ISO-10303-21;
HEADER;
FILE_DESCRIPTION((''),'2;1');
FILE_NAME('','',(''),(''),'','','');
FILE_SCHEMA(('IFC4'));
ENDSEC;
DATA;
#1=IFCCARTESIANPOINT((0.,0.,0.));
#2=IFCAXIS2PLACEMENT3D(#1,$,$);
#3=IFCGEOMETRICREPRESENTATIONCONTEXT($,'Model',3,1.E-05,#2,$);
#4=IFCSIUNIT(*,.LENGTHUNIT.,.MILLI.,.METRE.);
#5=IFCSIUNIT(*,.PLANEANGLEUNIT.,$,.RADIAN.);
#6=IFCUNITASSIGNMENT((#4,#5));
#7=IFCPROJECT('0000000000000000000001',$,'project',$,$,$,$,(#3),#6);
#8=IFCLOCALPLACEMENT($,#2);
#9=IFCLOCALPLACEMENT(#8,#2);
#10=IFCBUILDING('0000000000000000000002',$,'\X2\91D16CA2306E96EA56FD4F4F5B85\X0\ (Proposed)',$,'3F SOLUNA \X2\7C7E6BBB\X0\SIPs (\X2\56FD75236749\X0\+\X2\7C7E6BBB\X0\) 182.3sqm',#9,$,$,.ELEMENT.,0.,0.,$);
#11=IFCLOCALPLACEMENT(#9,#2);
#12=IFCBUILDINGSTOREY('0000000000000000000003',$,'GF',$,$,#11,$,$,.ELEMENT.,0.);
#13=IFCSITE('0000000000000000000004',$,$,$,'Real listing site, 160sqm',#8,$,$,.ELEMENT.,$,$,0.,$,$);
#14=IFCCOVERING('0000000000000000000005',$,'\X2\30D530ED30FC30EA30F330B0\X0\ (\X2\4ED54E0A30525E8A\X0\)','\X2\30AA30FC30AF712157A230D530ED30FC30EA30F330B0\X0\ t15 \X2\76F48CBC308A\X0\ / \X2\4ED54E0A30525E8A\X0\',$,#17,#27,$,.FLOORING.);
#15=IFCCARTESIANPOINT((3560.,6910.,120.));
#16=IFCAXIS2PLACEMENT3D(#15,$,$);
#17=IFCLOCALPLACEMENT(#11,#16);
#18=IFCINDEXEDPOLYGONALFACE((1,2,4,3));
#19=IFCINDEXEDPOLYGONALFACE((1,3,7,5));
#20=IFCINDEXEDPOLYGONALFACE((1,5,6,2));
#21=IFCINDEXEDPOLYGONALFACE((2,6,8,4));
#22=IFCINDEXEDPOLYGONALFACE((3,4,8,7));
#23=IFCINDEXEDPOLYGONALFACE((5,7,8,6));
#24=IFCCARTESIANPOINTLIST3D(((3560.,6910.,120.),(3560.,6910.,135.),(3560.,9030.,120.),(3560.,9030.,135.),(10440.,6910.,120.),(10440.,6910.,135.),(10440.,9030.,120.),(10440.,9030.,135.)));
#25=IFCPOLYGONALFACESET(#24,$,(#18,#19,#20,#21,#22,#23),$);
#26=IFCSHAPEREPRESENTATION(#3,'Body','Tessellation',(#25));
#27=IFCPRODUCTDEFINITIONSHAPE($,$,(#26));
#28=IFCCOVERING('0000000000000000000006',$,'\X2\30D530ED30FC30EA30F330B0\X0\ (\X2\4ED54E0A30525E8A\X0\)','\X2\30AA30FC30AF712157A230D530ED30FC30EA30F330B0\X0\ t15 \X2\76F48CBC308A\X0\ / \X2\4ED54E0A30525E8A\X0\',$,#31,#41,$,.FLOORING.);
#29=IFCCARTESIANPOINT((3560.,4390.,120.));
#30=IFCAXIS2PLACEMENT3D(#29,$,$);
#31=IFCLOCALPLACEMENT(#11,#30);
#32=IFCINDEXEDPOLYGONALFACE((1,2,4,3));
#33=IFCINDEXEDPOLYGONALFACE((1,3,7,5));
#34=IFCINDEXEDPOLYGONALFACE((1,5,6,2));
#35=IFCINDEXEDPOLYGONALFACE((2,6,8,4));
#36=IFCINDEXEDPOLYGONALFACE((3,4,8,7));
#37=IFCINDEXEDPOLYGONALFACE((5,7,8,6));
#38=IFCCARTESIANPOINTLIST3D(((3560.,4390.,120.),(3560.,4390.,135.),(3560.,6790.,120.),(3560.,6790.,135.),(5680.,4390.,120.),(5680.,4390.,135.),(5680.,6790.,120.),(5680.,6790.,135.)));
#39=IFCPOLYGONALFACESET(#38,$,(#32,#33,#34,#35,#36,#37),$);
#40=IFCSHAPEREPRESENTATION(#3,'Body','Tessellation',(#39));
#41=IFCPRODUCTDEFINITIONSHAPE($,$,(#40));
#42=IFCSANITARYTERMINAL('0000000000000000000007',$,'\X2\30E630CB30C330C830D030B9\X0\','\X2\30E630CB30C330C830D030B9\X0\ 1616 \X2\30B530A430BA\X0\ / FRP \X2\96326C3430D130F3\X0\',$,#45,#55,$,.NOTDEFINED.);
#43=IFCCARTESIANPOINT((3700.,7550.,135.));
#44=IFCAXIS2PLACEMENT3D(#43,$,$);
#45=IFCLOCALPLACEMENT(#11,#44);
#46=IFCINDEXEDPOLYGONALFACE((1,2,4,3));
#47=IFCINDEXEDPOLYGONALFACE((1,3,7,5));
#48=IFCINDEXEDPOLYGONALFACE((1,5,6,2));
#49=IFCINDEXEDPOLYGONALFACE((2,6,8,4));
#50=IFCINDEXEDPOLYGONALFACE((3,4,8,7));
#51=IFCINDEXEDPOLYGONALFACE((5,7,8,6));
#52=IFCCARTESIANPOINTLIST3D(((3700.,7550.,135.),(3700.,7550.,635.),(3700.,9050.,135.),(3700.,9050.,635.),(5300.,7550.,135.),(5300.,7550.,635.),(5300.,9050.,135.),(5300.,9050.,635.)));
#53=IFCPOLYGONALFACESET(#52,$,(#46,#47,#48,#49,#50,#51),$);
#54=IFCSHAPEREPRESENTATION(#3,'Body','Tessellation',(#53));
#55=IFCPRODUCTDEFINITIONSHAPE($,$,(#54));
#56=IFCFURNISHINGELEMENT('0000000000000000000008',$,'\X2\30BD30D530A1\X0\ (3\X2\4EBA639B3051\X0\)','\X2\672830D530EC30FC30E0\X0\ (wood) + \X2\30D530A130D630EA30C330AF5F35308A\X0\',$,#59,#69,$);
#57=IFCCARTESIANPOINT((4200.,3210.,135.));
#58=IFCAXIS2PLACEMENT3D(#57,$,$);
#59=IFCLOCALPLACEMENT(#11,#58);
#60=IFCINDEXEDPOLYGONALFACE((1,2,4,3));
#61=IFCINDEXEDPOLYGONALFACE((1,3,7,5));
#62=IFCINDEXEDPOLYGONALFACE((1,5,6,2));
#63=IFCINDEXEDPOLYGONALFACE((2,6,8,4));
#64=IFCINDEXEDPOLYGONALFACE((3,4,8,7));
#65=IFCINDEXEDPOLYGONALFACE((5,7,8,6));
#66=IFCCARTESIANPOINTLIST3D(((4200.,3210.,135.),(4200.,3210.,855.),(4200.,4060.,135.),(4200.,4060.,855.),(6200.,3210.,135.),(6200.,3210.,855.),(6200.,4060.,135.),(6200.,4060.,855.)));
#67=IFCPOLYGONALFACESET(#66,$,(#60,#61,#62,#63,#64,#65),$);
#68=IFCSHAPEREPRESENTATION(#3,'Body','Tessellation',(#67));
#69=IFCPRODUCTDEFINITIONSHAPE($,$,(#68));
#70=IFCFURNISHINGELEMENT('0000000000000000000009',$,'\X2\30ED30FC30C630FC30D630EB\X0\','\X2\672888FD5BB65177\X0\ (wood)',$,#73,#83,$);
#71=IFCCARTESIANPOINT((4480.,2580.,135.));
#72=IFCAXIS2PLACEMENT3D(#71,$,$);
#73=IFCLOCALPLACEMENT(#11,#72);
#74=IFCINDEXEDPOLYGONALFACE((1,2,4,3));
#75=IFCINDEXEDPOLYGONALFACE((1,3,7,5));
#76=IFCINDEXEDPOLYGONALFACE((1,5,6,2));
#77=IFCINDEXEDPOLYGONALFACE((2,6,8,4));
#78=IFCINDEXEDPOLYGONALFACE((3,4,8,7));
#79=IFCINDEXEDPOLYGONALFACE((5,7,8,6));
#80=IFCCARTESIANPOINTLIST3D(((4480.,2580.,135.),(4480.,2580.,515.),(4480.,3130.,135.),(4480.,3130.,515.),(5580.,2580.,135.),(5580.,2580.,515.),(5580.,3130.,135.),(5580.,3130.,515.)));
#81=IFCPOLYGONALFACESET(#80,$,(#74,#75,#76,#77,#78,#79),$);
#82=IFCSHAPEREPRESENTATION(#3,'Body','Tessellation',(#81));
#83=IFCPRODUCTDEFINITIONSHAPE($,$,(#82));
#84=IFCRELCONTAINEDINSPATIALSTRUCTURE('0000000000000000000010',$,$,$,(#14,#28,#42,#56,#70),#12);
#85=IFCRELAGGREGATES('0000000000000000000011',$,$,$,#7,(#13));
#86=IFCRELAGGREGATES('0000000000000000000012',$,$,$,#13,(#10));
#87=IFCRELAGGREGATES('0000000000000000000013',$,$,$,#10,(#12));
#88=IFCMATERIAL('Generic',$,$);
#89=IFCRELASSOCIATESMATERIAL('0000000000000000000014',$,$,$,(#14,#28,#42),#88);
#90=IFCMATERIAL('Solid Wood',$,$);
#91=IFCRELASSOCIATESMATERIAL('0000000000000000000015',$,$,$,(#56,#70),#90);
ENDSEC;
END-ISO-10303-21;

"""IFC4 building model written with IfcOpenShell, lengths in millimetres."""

from ifc_helpers import new_model, si_unit, frame, frame_2d, origin, place, context, project, spatial, rectangle, extrude, material, element, save


model = new_model("IFC4")

# Units and contexts
model_context = context("Model", 3, precision=1e-05, world=origin())
ifc_project = project(units=[si_unit("LENGTHUNIT", "METRE", prefix="MILLI"), si_unit("PLANEANGLEUNIT", "RADIAN")], contexts=[model_context])

# Site, building, storey
site_placement = place(None, origin())
site = spatial("IfcSite", under=ifc_project, at=site_placement, ObjectType="Real listing site, 160sqm", CompositionType="ELEMENT", RefElevation=0.0)
building_placement = place(site_placement, origin())
building = spatial("IfcBuilding", under=site, at=building_placement, Name="金沢の雪国住宅 (Proposed)", ObjectType="3F SOLUNA 籾殻SIPs (国産杉+籾殻) 182.3sqm", CompositionType="ELEMENT", ElevationOfRefHeight=0.0, ElevationOfTerrain=0.0)
storey_placement = place(building_placement, origin())
storey = spatial("IfcBuildingStorey", under=building, at=storey_placement, Name="GF", CompositionType="ELEMENT", Elevation=0.0)

# Shared definitions
ifc_material_1 = material(Name="Solid Wood")

# Coverings
ifc_material_2 = material(Name="Generic")
covering_1_placement = place(storey_placement, frame((3560.0, 6910.0, 120.0)))
element("IfcCovering", 1, at=covering_1_placement, inside=storey, material=ifc_material_2, Name="フローリング (仕上げ床)", Description="オーク無垢フローリング t15 直貼り / 仕上げ床", PredefinedType="FLOORING", context=model_context, shape_type="SweptSolid", body=[
    extrude(rectangle(XDim=6880.0, YDim=2120.0, at=frame_2d((3440.0, 1060.0))), frame((3560.0, 6910.0, 120.0)), (0.0, 0.0, 1.0), 15.0),
])
covering_2_placement = place(storey_placement, frame((3560.0, 4390.0, 120.0)))
element("IfcCovering", 2, at=covering_2_placement, inside=storey, material=ifc_material_2, Name="フローリング (仕上げ床)", Description="オーク無垢フローリング t15 直貼り / 仕上げ床", PredefinedType="FLOORING", context=model_context, shape_type="SweptSolid", body=[
    extrude(rectangle(XDim=2120.0, YDim=2400.0, at=frame_2d((1060.0, 1200.0))), frame((3560.0, 4390.0, 120.0)), (0.0, 0.0, 1.0), 15.0),
])

# Sanitary terminal
sanitary_terminal_placement = place(storey_placement, frame((3700.0, 7550.0, 135.0)))
element("IfcSanitaryTerminal", 3, at=sanitary_terminal_placement, inside=storey, material=ifc_material_2, Name="ユニットバス", Description="ユニットバス 1616 サイズ / FRP 防水パン", PredefinedType="NOTDEFINED", context=model_context, shape_type="SweptSolid", body=[
    extrude(rectangle(XDim=1600.0, YDim=1500.0, at=frame_2d((800.0, 750.0))), frame((3700.0, 7550.0, 135.0)), (0.0, 0.0, 1.0), 500.0),
])

# Furnishing elements
furnishing_1_placement = place(storey_placement, frame((4200.0, 3210.0, 135.0)))
element("IfcFurnishingElement", 4, at=furnishing_1_placement, inside=storey, material=ifc_material_1, Name="ソファ (3人掛け)", Description="木フレーム (wood) + ファブリック張り", context=model_context, shape_type="SweptSolid", body=[
    extrude(rectangle(XDim=2000.0, YDim=850.0, at=frame_2d((1000.0, 425.0))), frame((4200.0, 3210.0, 135.0)), (0.0, 0.0, 1.0), 720.0),
])
furnishing_2_placement = place(storey_placement, frame((4480.0, 2580.0, 135.0)))
element("IfcFurnishingElement", 5, at=furnishing_2_placement, inside=storey, material=ifc_material_1, Name="ローテーブル", Description="木製家具 (wood)", context=model_context, shape_type="SweptSolid", body=[
    extrude(rectangle(XDim=1100.0, YDim=550.0, at=frame_2d((550.0, 275.0))), frame((4480.0, 2580.0, 135.0)), (0.0, 0.0, 1.0), 380.0),
])

save(model, "model.ifc")
